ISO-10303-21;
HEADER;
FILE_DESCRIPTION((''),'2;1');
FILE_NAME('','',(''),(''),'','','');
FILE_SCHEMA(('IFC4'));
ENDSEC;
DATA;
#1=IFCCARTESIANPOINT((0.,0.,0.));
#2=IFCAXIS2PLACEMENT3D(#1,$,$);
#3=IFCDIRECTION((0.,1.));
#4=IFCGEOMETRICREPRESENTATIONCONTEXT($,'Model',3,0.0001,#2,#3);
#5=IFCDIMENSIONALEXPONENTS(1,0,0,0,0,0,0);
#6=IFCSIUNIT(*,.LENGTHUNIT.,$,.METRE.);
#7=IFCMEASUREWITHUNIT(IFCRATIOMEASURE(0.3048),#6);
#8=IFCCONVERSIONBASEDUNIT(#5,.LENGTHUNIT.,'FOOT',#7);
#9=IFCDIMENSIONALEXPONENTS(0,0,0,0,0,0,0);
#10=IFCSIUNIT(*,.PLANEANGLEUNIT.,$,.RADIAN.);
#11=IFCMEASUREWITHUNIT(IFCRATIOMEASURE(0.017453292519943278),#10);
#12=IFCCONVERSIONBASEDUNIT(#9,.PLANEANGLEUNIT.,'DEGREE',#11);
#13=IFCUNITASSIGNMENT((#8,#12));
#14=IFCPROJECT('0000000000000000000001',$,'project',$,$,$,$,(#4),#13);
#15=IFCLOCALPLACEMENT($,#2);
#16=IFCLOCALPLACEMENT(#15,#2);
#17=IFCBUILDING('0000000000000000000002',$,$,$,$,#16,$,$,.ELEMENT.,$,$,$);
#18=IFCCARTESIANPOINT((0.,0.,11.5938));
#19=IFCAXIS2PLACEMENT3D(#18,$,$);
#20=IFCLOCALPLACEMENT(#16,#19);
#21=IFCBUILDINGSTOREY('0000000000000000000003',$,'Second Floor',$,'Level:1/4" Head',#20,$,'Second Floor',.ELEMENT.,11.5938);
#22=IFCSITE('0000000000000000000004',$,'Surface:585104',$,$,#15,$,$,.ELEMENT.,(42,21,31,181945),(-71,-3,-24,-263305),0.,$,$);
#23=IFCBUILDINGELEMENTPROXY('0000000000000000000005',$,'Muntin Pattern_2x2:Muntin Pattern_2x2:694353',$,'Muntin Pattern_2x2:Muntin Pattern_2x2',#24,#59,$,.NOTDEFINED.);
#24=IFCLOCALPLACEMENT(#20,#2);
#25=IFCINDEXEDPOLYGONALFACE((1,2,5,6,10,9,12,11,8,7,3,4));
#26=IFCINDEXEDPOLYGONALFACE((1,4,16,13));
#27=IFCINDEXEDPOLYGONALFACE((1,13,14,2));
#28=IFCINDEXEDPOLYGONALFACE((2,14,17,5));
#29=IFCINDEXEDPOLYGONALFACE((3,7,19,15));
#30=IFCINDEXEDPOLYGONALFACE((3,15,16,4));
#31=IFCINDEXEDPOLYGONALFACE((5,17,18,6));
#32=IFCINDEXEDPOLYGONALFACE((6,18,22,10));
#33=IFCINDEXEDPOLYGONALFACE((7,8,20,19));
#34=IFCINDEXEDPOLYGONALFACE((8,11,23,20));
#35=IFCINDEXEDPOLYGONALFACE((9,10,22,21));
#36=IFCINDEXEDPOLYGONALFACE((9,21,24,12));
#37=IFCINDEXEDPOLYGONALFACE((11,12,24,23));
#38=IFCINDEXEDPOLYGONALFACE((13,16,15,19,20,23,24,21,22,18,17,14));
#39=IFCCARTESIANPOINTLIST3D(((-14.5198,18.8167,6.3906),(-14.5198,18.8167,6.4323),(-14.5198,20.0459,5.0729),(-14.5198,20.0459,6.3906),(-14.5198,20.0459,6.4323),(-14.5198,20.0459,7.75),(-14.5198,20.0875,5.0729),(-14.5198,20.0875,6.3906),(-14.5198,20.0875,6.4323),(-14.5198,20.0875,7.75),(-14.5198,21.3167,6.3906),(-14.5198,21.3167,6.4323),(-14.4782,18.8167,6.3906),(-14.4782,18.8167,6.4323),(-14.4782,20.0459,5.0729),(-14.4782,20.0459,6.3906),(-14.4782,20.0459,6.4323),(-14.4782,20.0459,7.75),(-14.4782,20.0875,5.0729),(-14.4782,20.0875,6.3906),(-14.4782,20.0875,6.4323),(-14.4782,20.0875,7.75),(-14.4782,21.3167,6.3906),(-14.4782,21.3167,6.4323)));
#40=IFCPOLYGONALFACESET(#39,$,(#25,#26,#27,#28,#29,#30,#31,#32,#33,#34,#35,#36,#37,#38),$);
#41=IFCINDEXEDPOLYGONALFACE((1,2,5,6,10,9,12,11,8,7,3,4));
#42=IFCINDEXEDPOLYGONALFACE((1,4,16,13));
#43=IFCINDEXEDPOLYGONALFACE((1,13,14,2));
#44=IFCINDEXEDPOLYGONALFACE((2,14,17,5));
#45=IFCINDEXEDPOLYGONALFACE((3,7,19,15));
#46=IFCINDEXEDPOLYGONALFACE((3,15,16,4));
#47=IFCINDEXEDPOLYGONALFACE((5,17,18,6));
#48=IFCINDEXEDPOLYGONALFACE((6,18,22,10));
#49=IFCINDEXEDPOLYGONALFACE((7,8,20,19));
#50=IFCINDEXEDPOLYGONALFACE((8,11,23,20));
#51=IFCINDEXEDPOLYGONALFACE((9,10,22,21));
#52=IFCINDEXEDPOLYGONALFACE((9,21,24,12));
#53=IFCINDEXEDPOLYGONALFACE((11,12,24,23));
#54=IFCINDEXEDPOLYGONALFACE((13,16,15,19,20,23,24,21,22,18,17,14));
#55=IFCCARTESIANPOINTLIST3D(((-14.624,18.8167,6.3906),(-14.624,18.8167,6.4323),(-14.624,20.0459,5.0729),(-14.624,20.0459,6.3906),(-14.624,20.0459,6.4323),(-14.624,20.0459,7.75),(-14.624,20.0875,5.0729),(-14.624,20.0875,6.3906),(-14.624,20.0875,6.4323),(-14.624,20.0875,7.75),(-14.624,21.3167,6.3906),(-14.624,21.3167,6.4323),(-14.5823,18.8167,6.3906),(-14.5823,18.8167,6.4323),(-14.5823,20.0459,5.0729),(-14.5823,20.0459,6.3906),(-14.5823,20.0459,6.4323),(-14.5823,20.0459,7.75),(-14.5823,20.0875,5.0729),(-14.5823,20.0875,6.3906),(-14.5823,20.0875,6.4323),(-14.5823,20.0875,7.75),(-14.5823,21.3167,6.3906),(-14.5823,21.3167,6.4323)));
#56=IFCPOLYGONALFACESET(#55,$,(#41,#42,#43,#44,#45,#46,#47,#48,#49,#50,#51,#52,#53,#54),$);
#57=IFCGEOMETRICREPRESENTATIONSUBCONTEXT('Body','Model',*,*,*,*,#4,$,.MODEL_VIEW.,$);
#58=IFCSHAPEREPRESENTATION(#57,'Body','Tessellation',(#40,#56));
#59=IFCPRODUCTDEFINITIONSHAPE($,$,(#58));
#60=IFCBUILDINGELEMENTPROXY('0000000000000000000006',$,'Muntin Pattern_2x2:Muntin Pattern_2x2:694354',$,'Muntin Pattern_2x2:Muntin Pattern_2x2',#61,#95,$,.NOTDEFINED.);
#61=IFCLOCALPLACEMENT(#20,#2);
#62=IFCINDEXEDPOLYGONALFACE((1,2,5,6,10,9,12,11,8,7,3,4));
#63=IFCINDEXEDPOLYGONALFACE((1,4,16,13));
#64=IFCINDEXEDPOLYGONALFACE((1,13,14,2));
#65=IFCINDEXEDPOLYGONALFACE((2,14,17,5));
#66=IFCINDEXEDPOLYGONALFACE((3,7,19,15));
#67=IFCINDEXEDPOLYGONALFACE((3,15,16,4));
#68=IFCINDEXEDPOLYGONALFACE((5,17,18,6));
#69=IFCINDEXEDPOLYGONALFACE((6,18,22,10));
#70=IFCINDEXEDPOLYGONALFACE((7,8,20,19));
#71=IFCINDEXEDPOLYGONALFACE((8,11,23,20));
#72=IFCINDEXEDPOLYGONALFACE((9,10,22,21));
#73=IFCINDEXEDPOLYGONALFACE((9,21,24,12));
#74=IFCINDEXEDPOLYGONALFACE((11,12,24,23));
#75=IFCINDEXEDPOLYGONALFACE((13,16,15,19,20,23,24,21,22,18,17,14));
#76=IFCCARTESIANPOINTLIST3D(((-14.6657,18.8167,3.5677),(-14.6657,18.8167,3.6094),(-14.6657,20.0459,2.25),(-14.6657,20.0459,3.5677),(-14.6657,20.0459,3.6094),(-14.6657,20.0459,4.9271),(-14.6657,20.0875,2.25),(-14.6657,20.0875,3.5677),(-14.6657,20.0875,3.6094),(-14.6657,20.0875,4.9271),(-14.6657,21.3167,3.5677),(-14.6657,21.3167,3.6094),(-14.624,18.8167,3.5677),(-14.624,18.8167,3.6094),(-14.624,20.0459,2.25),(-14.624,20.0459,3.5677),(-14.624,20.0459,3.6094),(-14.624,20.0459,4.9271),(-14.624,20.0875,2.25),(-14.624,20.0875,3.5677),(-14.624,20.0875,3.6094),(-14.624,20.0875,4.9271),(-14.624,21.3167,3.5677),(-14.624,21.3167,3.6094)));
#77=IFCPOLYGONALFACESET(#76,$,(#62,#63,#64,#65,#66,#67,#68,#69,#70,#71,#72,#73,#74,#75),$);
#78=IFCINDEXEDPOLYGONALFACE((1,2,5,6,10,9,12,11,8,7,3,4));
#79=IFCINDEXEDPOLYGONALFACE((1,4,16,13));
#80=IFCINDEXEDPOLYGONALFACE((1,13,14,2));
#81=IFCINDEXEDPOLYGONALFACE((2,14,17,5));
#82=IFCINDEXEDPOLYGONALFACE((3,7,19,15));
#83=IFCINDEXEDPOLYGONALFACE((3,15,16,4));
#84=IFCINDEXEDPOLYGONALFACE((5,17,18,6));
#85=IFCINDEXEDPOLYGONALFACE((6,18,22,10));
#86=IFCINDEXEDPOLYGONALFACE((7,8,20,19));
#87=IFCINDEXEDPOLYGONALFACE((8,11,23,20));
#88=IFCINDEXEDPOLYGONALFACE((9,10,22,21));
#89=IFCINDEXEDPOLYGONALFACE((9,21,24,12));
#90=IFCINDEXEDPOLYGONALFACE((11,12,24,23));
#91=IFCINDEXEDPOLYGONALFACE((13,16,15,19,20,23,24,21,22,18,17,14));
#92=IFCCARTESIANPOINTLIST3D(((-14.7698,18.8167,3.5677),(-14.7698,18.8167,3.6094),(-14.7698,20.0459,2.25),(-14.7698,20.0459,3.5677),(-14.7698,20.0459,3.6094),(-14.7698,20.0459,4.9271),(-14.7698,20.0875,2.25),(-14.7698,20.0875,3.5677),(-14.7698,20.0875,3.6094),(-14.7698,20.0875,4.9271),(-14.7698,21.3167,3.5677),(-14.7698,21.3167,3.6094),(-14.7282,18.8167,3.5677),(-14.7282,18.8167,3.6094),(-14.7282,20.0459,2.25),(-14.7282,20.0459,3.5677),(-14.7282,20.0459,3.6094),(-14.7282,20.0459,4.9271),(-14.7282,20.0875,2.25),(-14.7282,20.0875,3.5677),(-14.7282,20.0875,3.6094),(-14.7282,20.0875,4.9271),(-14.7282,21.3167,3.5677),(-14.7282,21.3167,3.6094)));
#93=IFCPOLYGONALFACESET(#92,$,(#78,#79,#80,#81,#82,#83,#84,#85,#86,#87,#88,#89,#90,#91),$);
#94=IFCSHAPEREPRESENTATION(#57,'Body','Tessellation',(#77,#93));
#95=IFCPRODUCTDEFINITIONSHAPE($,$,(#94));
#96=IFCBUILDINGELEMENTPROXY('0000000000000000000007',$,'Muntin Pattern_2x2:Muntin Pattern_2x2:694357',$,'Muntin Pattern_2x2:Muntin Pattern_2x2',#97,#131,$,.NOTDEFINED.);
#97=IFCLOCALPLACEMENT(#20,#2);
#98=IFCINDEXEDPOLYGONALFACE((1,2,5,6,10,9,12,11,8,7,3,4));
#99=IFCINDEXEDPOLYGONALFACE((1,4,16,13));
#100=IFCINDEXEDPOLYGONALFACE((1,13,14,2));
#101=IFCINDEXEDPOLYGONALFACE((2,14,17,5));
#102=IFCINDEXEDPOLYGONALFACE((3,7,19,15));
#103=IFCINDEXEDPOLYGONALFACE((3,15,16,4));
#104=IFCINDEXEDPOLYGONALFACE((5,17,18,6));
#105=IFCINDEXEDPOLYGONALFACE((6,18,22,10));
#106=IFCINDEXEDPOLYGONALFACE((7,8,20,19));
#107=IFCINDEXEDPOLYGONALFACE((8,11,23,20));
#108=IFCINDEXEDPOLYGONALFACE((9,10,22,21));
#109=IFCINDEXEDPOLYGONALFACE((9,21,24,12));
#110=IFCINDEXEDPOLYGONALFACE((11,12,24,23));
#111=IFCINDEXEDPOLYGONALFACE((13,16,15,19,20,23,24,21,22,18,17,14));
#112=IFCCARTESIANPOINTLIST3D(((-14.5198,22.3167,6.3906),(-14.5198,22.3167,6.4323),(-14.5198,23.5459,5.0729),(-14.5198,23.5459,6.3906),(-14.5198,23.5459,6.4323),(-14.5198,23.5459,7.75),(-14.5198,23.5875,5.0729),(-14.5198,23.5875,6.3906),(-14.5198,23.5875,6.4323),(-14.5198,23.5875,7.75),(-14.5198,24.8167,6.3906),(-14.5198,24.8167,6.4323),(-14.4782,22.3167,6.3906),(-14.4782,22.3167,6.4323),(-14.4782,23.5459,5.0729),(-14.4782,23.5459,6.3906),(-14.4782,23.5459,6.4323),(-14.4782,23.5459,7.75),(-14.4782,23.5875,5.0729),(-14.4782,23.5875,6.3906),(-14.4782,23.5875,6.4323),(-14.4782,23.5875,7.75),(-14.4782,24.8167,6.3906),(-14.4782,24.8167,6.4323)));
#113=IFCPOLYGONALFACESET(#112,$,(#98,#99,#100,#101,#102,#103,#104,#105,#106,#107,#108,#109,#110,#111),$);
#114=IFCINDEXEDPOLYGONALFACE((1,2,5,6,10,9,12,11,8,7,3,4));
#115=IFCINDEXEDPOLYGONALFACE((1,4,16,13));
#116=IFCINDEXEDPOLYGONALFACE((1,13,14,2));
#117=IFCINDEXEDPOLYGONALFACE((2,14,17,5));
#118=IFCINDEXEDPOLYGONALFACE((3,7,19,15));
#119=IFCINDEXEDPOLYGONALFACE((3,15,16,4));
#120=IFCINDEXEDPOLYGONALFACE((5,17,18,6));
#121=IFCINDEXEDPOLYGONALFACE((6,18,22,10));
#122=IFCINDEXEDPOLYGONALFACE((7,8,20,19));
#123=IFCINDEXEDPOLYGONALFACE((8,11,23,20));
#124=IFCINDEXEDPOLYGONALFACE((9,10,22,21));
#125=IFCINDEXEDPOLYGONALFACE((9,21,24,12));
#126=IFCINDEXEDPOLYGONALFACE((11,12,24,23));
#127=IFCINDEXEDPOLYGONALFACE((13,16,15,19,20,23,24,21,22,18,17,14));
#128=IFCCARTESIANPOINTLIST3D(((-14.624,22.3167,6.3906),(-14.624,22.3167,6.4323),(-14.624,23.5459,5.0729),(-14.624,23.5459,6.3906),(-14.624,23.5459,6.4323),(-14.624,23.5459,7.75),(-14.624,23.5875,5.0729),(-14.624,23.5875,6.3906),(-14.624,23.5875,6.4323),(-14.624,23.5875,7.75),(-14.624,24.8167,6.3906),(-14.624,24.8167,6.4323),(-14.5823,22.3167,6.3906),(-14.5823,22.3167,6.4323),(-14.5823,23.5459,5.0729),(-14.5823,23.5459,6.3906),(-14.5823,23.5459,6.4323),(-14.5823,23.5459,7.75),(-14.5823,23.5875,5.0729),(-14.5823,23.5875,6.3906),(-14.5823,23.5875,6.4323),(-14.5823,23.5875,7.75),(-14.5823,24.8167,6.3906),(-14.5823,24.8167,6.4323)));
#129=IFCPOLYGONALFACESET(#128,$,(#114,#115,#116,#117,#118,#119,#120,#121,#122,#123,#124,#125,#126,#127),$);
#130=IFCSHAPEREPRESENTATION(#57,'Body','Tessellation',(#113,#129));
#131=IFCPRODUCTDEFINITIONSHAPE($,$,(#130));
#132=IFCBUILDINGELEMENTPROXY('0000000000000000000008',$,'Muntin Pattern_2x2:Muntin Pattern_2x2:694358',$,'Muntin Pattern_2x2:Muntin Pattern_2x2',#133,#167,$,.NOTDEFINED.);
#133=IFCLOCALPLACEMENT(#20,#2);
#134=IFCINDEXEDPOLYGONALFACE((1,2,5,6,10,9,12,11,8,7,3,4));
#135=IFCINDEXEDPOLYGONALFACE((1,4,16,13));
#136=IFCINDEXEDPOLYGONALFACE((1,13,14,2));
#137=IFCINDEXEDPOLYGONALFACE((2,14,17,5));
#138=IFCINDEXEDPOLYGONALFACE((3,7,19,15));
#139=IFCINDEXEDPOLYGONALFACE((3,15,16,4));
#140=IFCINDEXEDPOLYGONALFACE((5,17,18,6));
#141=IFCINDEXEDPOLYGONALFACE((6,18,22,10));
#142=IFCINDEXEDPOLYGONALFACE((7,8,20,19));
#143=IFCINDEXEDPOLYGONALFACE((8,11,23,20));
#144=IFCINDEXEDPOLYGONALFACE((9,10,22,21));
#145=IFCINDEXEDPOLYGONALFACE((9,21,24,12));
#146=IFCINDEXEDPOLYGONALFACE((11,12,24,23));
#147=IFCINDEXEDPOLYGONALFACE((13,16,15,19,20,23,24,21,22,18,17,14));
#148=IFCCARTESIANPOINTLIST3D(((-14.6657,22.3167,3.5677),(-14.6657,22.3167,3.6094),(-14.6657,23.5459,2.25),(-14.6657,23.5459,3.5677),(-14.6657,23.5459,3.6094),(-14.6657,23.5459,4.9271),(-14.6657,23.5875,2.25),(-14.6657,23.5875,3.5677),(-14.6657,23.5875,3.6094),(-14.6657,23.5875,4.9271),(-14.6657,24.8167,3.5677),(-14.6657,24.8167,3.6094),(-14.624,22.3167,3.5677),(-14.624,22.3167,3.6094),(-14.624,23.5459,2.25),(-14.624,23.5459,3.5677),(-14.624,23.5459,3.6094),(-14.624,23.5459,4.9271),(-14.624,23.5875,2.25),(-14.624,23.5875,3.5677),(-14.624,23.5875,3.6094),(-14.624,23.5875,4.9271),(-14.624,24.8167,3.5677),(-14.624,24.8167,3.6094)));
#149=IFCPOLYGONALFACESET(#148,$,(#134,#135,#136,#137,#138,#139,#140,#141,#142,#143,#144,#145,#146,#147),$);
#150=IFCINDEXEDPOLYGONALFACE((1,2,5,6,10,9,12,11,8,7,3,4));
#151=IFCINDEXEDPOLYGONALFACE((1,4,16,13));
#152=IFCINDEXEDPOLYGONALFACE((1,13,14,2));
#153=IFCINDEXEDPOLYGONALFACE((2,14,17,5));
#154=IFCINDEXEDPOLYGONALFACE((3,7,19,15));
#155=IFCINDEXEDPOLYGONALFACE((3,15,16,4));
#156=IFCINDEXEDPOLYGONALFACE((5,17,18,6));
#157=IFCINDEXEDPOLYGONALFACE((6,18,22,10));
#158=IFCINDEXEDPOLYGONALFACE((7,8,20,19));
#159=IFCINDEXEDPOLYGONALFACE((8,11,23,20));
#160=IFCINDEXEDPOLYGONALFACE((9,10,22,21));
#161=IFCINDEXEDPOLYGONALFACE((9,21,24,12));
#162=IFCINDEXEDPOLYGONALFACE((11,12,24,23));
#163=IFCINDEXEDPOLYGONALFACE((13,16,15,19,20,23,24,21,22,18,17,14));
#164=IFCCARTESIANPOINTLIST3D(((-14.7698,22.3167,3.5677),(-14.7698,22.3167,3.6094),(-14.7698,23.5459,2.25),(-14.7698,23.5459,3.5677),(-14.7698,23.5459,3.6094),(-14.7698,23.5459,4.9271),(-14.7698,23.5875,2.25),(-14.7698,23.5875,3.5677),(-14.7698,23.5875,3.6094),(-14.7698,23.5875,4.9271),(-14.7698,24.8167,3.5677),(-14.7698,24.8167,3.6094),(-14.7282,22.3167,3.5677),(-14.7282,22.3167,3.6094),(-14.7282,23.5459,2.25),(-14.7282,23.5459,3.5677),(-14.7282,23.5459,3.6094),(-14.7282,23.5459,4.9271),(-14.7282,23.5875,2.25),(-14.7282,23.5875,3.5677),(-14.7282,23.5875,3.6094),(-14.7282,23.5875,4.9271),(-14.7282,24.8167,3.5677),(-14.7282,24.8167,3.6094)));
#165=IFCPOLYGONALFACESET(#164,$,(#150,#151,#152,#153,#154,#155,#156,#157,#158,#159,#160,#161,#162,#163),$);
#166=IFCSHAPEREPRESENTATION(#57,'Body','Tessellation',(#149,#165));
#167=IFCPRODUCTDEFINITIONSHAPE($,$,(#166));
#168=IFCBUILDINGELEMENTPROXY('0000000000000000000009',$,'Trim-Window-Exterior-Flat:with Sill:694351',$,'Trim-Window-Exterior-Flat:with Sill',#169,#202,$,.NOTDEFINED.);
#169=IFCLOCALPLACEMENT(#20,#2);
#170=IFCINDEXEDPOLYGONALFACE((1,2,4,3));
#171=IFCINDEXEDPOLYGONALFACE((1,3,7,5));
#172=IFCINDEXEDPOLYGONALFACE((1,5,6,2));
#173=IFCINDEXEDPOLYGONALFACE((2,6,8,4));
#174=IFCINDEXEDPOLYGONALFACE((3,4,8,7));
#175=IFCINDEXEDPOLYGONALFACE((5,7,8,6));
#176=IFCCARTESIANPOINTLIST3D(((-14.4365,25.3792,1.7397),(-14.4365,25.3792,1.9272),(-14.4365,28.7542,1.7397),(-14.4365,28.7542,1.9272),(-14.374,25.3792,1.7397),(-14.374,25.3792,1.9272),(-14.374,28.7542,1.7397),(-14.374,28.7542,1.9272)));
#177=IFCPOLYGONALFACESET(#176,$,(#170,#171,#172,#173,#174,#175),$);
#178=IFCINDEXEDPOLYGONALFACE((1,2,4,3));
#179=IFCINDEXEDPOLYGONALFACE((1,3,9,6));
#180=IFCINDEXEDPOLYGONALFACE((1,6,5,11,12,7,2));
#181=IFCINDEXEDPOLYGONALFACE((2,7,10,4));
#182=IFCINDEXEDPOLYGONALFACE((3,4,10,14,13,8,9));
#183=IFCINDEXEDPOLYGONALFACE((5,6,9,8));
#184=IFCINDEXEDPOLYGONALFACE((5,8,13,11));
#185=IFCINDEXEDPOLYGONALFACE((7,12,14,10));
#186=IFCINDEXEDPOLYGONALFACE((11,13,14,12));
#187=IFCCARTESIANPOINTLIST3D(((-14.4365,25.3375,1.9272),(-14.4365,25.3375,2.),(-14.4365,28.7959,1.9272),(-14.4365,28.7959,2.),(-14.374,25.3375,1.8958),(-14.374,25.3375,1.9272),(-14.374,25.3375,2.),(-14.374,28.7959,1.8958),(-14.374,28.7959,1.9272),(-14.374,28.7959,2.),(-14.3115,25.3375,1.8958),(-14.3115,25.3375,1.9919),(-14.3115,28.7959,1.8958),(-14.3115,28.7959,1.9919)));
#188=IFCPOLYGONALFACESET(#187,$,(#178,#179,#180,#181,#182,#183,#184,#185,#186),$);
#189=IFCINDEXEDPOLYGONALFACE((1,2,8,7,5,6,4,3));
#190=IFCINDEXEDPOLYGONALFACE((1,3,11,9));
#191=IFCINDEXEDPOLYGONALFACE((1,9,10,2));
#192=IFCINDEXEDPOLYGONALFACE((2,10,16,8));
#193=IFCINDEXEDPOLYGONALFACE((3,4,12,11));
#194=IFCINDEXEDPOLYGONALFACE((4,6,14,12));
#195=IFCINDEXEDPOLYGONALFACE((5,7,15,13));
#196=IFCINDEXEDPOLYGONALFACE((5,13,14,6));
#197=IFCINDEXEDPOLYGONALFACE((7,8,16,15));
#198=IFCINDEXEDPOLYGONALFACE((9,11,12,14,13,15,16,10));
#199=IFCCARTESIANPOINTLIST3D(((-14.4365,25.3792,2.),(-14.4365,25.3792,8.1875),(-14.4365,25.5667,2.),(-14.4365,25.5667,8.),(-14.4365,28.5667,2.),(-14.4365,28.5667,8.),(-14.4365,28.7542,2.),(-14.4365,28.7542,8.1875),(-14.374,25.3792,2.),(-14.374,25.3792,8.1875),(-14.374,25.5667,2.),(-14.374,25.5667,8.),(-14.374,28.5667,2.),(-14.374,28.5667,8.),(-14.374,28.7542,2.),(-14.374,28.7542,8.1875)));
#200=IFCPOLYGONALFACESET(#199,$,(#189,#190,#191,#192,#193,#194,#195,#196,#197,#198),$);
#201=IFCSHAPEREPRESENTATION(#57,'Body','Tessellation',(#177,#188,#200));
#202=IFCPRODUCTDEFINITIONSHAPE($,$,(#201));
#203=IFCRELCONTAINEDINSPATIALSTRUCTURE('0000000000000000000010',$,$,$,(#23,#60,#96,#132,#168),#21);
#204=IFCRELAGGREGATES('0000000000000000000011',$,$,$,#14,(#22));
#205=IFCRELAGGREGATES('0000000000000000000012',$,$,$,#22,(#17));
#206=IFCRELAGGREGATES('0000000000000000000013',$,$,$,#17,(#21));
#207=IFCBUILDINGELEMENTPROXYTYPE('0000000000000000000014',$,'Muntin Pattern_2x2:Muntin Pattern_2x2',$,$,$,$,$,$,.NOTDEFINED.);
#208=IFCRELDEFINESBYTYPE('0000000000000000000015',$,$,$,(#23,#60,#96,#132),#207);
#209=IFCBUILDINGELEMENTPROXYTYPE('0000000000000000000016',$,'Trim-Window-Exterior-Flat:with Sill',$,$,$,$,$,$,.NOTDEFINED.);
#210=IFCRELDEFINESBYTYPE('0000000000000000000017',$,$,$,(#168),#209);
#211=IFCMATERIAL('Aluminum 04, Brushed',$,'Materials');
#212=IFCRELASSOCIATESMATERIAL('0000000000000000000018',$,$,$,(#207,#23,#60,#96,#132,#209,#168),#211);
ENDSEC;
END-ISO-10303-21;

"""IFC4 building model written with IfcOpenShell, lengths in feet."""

from ifc_helpers import new_model, entity, si_unit, converted_unit, direction, frame, origin, place, context, subcontext, project, spatial, indexed_curve, outline, extrude, source, transform, mapped, material, type_object, type_shapes, element, save


model = new_model("IFC4")

# Units and contexts
model_context = context("Model", 3, precision=0.0001, world=origin(), true_north=direction((0.0, 1.0)))
body_context = subcontext(model_context, "Body", "Model", "MODEL_VIEW")
ifc_project = project(units=[converted_unit("LENGTHUNIT", "FOOT", entity("IfcRatioMeasure", 0.3048), si_unit("LENGTHUNIT", "METRE"), dimensions=[1, 0, 0, 0, 0, 0, 0]), converted_unit("PLANEANGLEUNIT", "DEGREE", entity("IfcRatioMeasure", 0.017453292519943278), si_unit("PLANEANGLEUNIT", "RADIAN"), dimensions=[0, 0, 0, 0, 0, 0, 0])], contexts=[model_context])

# Site, building, storey
site_placement = place(None, origin())
site = spatial("IfcSite", under=ifc_project, at=site_placement, Name="Surface:585104", CompositionType="ELEMENT", RefLatitude=(42, 21, 31, 181945), RefLongitude=(-71, -3, -24, -263305), RefElevation=0.0)
building_placement = place(site_placement, origin())
building = spatial("IfcBuilding", under=site, at=building_placement, CompositionType="ELEMENT")
storey_placement = place(building_placement, frame((0.0, 0.0, 11.5938)))
storey = spatial("IfcBuildingStorey", under=building, at=storey_placement, Name="Second Floor", ObjectType="Level:1/4\" Head", LongName="Second Floor", CompositionType="ELEMENT", Elevation=11.5938)

# Building element proxies
ifc_material_1 = material(Name="Aluminum 04, Brushed", Category="Materials")
building_element_proxy_type_1 = type_object("IfcBuildingElementProxyType", Name="Muntin Pattern_2x2:Muntin Pattern_2x2", PredefinedType="NOTDEFINED", material=ifc_material_1)
shared_shape_1 = source(origin(), body_context, "Body", "SweptSolid", [
    extrude(outline(indexed_curve([(0.0208, -0.0208), (1.3385, -0.0208), (1.3385, 0.0208), (0.0208, 0.0208), (0.0208, 1.25), (-0.0208, 1.25), (-0.0208, 0.0208), (-1.3385, 0.0208), (-1.3385, -0.0208), (-0.0208, -0.0208), (-0.0208, -1.25), (0.0208, -1.25), (0.0208, -0.0208)], self_intersect=False)), frame((0.0, 0.0312, 1.3385), z_axis=(0.0, 1.0, 0.0), x_axis=(0.0, 0.0, 1.0)), (0.0, 0.0, 1.0), 0.0417),
    extrude(outline(indexed_curve([(0.0208, -0.0208), (1.3385, -0.0208), (1.3385, 0.0208), (0.0208, 0.0208), (0.0208, 1.25), (-0.0208, 1.25), (-0.0208, 0.0208), (-1.3385, 0.0208), (-1.3385, -0.0208), (-0.0208, -0.0208), (-0.0208, -1.25), (0.0208, -1.25), (0.0208, -0.0208)], self_intersect=False)), frame((0.0, -0.0729, 1.3385), z_axis=(0.0, 1.0, 0.0), x_axis=(0.0, 0.0, 1.0)), (0.0, 0.0, 1.0), 0.0417),
])
type_shapes(building_element_proxy_type_1, [shared_shape_1])
for number, where, z_axis, x_axis, name in (
    (1, (-14.5511, 20.0667, 5.0729), (0.0, 0.0, 1.0), (0.0, -1.0, 0.0), "Muntin Pattern_2x2:Muntin Pattern_2x2:694353"),
    (2, (-14.6969, 20.0667, 2.25), (0.0, 0.0, 1.0), (0.0, -1.0, 0.0), "Muntin Pattern_2x2:Muntin Pattern_2x2:694354"),
    (3, (-14.5511, 23.5667, 5.0729), (0.0, 0.0, 1.0), (0.0, -1.0, 0.0), "Muntin Pattern_2x2:Muntin Pattern_2x2:694357"),
    (4, (-14.6969, 23.5667, 2.25), (0.0, 0.0, 1.0), (0.0, -1.0, 0.0), "Muntin Pattern_2x2:Muntin Pattern_2x2:694358"),
):
    element("IfcBuildingElementProxy", number, at=place(storey_placement, frame(where, z_axis=z_axis, x_axis=x_axis)), inside=storey, type_object=building_element_proxy_type_1, material=ifc_material_1, Name=name, ObjectType="Muntin Pattern_2x2:Muntin Pattern_2x2", PredefinedType="NOTDEFINED", context=body_context, shape_type="MappedRepresentation", body=[
        mapped(shared_shape_1, transform((0.0, 0.0, 0.0), scale=1.0)),
    ])
building_element_proxy_type_2 = type_object("IfcBuildingElementProxyType", Name="Trim-Window-Exterior-Flat:with Sill", PredefinedType="NOTDEFINED", material=ifc_material_1)
shared_shape_2 = source(origin(), body_context, "Body", "SweptSolid", [
    extrude(outline(indexed_curve([(-1.6875, -0.0938), (1.6875, -0.0938), (1.6875, 0.0938), (-1.6875, 0.0938), (-1.6875, -0.0938)], self_intersect=False)), frame((0.0, -6.1665, 0.0), z_axis=(0.0, 0.0, 1.0), x_axis=(-1.0, 0.0, 0.0)), (0.0, 0.0, 1.0), 0.0625),
    extrude(outline(indexed_curve([(-0.0625, -0.0525), (0.0, -0.0525), (0.0, -0.0211), (0.0625, -0.0211), (0.0625, 0.0517), (0.0, 0.0517), (-0.0625, 0.0436), (-0.0625, -0.0525)], self_intersect=False)), frame((-1.7292, -6.0517, 0.0625), z_axis=(1.0, 0.0, 0.0), x_axis=(0.0, 0.0, -1.0)), (0.0, 0.0, 1.0), 3.4583),
    extrude(outline(indexed_curve([(-3.1406, -1.6875), (3.0469, -1.6875), (3.0469, -1.5), (-2.9531, -1.5), (-2.9531, 1.5), (3.0469, 1.5), (3.0469, 1.6875), (-3.1406, 1.6875), (-3.1406, -1.6875)], self_intersect=False)), frame((0.0, -2.9531, 0.0), z_axis=(0.0, 0.0, 1.0), x_axis=(0.0, -1.0, 0.0)), (0.0, 0.0, 1.0), 0.0625),
])
type_shapes(building_element_proxy_type_2, [shared_shape_2])
for number, where, z_axis, x_axis, name in (
    (5, (-14.4365, 27.0667, 8.0), (1.0, 0.0, 0.0), (0.0, 1.0, 0.0), "Trim-Window-Exterior-Flat:with Sill:694351"),
):
    element("IfcBuildingElementProxy", number, at=place(storey_placement, frame(where, z_axis=z_axis, x_axis=x_axis)), inside=storey, type_object=building_element_proxy_type_2, material=ifc_material_1, Name=name, ObjectType="Trim-Window-Exterior-Flat:with Sill", PredefinedType="NOTDEFINED", context=body_context, shape_type="MappedRepresentation", body=[
        mapped(shared_shape_2, transform((0.0, 0.0, 0.0), scale=1.0)),
    ])

save(model, "model.ifc")
